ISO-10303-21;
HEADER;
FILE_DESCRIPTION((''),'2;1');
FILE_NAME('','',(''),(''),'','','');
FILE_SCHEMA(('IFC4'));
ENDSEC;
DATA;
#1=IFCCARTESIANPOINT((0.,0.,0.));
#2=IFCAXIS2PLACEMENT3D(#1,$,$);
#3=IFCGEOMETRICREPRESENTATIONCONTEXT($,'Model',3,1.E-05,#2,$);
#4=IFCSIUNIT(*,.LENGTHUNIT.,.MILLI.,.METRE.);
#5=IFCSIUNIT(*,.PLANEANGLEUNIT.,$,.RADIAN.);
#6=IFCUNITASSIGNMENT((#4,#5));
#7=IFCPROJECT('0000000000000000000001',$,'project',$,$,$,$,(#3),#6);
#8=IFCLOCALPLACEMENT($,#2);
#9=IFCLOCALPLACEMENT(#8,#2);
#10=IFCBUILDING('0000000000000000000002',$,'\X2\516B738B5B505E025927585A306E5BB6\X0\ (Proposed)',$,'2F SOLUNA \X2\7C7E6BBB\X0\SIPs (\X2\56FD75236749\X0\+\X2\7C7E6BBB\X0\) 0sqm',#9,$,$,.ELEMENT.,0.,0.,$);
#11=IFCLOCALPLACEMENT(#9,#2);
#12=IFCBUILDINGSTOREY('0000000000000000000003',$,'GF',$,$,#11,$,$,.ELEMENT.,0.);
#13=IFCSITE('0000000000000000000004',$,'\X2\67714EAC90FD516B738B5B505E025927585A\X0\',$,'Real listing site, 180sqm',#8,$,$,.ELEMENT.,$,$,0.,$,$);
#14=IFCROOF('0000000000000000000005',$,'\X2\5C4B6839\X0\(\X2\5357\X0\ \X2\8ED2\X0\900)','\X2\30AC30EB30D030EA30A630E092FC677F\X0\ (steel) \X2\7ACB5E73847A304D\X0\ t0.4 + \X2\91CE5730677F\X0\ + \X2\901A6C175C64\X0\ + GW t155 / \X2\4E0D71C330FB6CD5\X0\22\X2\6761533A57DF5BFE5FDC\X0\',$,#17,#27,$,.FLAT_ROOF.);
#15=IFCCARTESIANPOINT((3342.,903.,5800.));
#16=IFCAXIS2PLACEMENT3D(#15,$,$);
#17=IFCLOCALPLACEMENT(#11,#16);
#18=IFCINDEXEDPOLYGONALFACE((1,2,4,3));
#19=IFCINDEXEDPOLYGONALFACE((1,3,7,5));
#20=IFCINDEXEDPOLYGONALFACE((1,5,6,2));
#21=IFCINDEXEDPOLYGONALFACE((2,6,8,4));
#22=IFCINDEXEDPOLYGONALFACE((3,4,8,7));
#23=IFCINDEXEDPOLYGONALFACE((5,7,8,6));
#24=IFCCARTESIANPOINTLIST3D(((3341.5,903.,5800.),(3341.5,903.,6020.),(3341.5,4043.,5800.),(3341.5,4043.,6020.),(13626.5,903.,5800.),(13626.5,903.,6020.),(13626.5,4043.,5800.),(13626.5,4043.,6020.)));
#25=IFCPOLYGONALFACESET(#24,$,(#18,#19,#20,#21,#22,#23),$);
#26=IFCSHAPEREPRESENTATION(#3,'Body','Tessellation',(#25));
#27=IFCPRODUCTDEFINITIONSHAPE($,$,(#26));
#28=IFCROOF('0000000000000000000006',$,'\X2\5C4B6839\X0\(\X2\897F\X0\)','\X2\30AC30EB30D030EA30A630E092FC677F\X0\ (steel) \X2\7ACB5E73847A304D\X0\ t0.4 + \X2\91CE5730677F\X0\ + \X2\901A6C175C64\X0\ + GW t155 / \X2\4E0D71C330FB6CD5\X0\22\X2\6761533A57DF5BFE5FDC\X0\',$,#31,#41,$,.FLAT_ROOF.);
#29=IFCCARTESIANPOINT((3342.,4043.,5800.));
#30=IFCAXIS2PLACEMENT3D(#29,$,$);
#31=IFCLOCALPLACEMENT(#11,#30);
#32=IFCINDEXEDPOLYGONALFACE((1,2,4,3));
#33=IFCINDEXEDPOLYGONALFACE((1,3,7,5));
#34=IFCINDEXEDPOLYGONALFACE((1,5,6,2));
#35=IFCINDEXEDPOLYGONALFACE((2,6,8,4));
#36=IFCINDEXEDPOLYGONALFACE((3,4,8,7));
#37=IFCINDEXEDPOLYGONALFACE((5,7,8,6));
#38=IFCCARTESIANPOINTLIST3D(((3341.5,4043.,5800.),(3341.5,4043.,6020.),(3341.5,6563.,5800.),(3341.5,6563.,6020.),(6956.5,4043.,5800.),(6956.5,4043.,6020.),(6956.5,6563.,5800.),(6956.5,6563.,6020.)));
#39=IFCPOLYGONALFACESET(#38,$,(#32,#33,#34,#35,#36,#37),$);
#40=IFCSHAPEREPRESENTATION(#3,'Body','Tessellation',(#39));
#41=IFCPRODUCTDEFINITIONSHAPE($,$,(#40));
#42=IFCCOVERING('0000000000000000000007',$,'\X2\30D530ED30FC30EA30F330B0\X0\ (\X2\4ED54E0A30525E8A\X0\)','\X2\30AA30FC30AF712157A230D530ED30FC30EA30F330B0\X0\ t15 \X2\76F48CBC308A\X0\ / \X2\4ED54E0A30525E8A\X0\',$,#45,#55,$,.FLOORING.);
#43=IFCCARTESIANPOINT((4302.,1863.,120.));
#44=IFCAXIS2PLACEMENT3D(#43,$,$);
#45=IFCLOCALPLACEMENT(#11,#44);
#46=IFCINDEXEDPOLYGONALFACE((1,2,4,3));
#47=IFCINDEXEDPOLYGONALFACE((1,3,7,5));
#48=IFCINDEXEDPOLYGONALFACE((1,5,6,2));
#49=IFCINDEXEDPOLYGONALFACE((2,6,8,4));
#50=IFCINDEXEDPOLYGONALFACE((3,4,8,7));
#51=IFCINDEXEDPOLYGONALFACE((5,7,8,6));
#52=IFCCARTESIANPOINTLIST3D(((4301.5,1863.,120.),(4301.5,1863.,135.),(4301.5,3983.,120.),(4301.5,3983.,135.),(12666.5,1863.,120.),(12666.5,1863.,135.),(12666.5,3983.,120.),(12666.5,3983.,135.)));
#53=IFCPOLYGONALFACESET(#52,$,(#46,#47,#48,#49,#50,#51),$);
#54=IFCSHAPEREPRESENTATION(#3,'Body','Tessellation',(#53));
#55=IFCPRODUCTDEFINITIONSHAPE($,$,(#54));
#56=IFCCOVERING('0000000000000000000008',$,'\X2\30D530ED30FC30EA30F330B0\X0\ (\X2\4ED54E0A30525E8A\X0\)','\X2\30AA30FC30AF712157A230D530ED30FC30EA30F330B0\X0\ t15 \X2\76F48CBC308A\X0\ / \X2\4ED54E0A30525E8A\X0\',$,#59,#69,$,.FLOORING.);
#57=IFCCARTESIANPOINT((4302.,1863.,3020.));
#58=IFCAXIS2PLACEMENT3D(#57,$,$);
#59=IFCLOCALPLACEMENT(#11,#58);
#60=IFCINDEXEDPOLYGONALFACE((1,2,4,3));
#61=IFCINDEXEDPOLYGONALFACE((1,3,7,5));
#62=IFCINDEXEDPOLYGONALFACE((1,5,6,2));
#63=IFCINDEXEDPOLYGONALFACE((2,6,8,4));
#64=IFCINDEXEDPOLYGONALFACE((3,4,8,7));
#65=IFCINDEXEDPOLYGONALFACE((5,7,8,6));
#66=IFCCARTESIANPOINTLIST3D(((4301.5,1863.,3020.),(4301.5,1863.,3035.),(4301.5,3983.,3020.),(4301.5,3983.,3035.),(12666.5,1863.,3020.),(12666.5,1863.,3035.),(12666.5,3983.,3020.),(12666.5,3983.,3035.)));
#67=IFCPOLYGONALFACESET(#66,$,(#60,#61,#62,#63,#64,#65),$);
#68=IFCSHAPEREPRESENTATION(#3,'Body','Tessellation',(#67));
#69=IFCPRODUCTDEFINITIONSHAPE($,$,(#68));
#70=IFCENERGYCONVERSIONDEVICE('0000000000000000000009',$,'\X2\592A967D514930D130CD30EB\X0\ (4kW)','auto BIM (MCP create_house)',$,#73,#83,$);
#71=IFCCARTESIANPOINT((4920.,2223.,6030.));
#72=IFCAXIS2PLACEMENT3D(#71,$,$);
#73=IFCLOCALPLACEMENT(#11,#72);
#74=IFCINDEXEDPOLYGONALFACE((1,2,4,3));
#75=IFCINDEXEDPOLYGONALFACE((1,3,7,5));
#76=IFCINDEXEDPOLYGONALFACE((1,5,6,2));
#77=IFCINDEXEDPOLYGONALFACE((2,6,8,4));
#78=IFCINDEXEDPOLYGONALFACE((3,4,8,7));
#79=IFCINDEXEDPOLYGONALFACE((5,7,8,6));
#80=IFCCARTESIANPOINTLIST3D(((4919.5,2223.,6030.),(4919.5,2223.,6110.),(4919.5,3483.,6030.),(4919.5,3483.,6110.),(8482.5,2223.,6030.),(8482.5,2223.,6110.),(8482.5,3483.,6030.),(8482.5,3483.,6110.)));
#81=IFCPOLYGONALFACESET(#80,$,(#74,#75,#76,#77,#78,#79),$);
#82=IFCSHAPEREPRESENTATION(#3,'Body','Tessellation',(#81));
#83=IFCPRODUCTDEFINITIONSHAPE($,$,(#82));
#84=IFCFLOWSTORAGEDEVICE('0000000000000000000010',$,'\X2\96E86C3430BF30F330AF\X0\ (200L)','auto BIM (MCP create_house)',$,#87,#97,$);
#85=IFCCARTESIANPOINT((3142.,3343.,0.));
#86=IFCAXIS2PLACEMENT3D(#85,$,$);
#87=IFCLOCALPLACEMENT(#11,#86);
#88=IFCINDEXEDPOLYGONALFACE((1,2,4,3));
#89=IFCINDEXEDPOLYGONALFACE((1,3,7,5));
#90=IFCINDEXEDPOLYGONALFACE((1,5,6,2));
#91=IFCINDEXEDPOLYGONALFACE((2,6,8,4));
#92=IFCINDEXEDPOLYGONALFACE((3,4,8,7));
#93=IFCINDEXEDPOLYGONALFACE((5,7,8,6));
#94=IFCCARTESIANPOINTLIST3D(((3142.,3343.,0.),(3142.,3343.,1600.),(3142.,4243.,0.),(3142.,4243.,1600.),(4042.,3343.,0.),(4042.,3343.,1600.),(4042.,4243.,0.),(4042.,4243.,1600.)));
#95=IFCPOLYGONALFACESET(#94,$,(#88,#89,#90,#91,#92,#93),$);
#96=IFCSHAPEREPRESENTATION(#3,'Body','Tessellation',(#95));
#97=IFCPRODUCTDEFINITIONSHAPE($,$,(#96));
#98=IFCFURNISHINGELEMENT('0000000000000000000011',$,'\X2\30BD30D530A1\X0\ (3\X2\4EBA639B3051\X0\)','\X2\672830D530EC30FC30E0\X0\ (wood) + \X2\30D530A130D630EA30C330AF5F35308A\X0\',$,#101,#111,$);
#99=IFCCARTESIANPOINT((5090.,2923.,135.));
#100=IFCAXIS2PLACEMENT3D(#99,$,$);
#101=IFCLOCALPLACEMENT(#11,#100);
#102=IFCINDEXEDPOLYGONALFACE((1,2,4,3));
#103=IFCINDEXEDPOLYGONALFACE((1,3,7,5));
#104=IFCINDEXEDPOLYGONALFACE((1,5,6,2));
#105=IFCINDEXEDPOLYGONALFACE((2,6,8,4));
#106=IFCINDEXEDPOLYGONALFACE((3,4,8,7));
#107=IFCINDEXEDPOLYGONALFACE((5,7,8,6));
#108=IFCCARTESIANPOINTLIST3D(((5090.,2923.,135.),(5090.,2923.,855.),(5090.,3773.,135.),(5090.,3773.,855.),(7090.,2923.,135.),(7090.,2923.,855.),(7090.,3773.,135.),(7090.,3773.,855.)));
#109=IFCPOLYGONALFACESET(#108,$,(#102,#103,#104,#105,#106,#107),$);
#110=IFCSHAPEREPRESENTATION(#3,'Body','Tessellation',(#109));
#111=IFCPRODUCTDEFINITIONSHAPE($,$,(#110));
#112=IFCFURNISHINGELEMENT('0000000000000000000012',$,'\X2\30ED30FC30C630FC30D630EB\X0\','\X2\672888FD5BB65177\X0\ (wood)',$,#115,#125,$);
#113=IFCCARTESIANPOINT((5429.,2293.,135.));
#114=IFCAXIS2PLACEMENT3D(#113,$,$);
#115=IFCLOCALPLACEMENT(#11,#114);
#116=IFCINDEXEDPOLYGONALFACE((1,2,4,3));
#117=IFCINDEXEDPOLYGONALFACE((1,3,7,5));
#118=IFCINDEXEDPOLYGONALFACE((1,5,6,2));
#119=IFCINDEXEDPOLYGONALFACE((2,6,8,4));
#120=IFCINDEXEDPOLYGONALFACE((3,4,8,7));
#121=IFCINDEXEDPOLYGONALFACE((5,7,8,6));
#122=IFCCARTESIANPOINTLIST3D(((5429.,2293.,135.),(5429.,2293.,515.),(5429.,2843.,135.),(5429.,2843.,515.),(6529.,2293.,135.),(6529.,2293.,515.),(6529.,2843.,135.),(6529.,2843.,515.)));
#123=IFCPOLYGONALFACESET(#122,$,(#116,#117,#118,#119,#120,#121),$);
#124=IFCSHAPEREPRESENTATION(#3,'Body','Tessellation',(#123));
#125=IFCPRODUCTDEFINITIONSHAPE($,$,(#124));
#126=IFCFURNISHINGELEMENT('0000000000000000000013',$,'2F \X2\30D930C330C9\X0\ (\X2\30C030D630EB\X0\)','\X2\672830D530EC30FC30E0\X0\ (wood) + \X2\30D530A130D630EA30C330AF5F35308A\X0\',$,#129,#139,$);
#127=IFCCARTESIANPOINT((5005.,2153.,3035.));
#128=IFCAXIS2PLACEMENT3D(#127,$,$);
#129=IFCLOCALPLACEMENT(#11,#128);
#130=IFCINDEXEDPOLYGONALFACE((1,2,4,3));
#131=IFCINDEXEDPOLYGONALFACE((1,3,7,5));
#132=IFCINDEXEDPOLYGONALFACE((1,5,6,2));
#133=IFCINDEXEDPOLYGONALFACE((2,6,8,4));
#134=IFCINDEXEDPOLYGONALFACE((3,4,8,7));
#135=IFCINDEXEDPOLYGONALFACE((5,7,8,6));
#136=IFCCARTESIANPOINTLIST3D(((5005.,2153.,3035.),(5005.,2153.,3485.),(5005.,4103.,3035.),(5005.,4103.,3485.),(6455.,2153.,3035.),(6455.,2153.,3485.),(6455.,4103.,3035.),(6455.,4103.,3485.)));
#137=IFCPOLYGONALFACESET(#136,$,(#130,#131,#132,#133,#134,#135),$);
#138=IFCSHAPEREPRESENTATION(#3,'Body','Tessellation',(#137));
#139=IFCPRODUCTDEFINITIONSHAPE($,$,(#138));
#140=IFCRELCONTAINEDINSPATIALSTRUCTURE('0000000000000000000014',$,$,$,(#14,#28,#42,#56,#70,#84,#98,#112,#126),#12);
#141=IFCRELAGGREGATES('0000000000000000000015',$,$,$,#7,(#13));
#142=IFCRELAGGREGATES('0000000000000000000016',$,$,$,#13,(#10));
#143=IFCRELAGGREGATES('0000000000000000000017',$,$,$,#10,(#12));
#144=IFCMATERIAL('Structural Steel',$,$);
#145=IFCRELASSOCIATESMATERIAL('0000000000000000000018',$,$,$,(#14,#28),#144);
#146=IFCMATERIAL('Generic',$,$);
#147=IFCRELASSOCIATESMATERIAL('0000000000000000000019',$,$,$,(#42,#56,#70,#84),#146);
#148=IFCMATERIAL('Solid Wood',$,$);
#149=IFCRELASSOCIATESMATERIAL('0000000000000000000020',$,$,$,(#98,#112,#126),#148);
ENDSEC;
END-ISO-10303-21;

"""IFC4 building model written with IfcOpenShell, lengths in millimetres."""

from ifc_helpers import new_model, si_unit, frame, frame_2d, origin, place, context, project, spatial, rectangle, extrude, material, element, save


model = new_model("IFC4")

# Units and contexts
model_context = context("Model", 3, precision=1e-05, world=origin())
ifc_project = project(units=[si_unit("LENGTHUNIT", "METRE", prefix="MILLI"), si_unit("PLANEANGLEUNIT", "RADIAN")], contexts=[model_context])

# Site, building, storey
site_placement = place(None, origin())
site = spatial("IfcSite", under=ifc_project, at=site_placement, Name="東京都八王子市大塚", ObjectType="Real listing site, 180sqm", CompositionType="ELEMENT", RefElevation=0.0)
building_placement = place(site_placement, origin())
building = spatial("IfcBuilding", under=site, at=building_placement, Name="八王子市大塚の家 (Proposed)", ObjectType="2F SOLUNA 籾殻SIPs (国産杉+籾殻) 0sqm", CompositionType="ELEMENT", ElevationOfRefHeight=0.0, ElevationOfTerrain=0.0)
storey_placement = place(building_placement, origin())
storey = spatial("IfcBuildingStorey", under=building, at=storey_placement, Name="GF", CompositionType="ELEMENT", Elevation=0.0)

# Shared definitions
ifc_material_1 = material(Name="Solid Wood")

# Roofs
ifc_material_2 = material(Name="Structural Steel")
roof_1_placement = place(storey_placement, frame((3342.0, 903.0, 5800.0)))
element("IfcRoof", 1, at=roof_1_placement, inside=storey, material=ifc_material_2, Name="屋根(南 軒900)", Description="ガルバリウム鋼板 (steel) 立平葺き t0.4 + 野地板 + 通気層 + GW t155 / 不燃・法22条区域対応", PredefinedType="FLAT_ROOF", context=model_context, shape_type="SweptSolid", body=[
    extrude(rectangle(XDim=10285.0, YDim=3140.0, at=frame_2d((5142.0, 1570.0))), frame((3342.0, 903.0, 5800.0)), (0.0, 0.0, 1.0), 220.0),
])
roof_2_placement = place(storey_placement, frame((3342.0, 4043.0, 5800.0)))
element("IfcRoof", 2, at=roof_2_placement, inside=storey, material=ifc_material_2, Name="屋根(西)", Description="ガルバリウム鋼板 (steel) 立平葺き t0.4 + 野地板 + 通気層 + GW t155 / 不燃・法22条区域対応", PredefinedType="FLAT_ROOF", context=model_context, shape_type="SweptSolid", body=[
    extrude(rectangle(XDim=3615.0, YDim=2520.0, at=frame_2d((1807.0, 1260.0))), frame((3342.0, 4043.0, 5800.0)), (0.0, 0.0, 1.0), 220.0),
])

# Coverings
ifc_material_3 = material(Name="Generic")
covering_1_placement = place(storey_placement, frame((4302.0, 1863.0, 120.0)))
element("IfcCovering", 3, at=covering_1_placement, inside=storey, material=ifc_material_3, Name="フローリング (仕上げ床)", Description="オーク無垢フローリング t15 直貼り / 仕上げ床", PredefinedType="FLOORING", context=model_context, shape_type="SweptSolid", body=[
    extrude(rectangle(XDim=8365.0, YDim=2120.0, at=frame_2d((4182.0, 1060.0))), frame((4302.0, 1863.0, 120.0)), (0.0, 0.0, 1.0), 15.0),
])
covering_2_placement = place(storey_placement, frame((4302.0, 1863.0, 3020.0)))
element("IfcCovering", 4, at=covering_2_placement, inside=storey, material=ifc_material_3, Name="フローリング (仕上げ床)", Description="オーク無垢フローリング t15 直貼り / 仕上げ床", PredefinedType="FLOORING", context=model_context, shape_type="SweptSolid", body=[
    extrude(rectangle(XDim=8365.0, YDim=2120.0, at=frame_2d((4182.0, 1060.0))), frame((4302.0, 1863.0, 3020.0)), (0.0, 0.0, 1.0), 15.0),
])

# Energy conversion device
energy_conversion_device_placement = place(storey_placement, frame((4920.0, 2223.0, 6030.0)))
element("IfcEnergyConversionDevice", 5, at=energy_conversion_device_placement, inside=storey, material=ifc_material_3, Name="太陽光パネル (4kW)", Description="auto BIM (MCP create_house)", context=model_context, shape_type="SweptSolid", body=[
    extrude(rectangle(XDim=3563.0, YDim=1260.0, at=frame_2d((1781.0, 630.0))), frame((4920.0, 2223.0, 6030.0)), (0.0, 0.0, 1.0), 80.0),
])

# Flow storage device
flow_storage_device_placement = place(storey_placement, frame((3142.0, 3343.0, 0.0)))
element("IfcFlowStorageDevice", 6, at=flow_storage_device_placement, inside=storey, material=ifc_material_3, Name="雨水タンク (200L)", Description="auto BIM (MCP create_house)", context=model_context, shape_type="SweptSolid", body=[
    extrude(rectangle(XDim=900.0, YDim=900.0, at=frame_2d((450.0, 450.0))), frame((3142.0, 3343.0, 0.0)), (0.0, 0.0, 1.0), 1600.0),
])

# Furnishing elements
furnishing_1_placement = place(storey_placement, frame((5090.0, 2923.0, 135.0)))
element("IfcFurnishingElement", 7, at=furnishing_1_placement, inside=storey, material=ifc_material_1, Name="ソファ (3人掛け)", Description="木フレーム (wood) + ファブリック張り", context=model_context, shape_type="SweptSolid", body=[
    extrude(rectangle(XDim=2000.0, YDim=850.0, at=frame_2d((1000.0, 425.0))), frame((5090.0, 2923.0, 135.0)), (0.0, 0.0, 1.0), 720.0),
])
furnishing_2_placement = place(storey_placement, frame((5429.0, 2293.0, 135.0)))
element("IfcFurnishingElement", 8, at=furnishing_2_placement, inside=storey, material=ifc_material_1, Name="ローテーブル", Description="木製家具 (wood)", context=model_context, shape_type="SweptSolid", body=[
    extrude(rectangle(XDim=1100.0, YDim=550.0, at=frame_2d((550.0, 275.0))), frame((5429.0, 2293.0, 135.0)), (0.0, 0.0, 1.0), 380.0),
])
furnishing_3_placement = place(storey_placement, frame((5005.0, 2153.0, 3035.0)))
element("IfcFurnishingElement", 9, at=furnishing_3_placement, inside=storey, material=ifc_material_1, Name="2F ベッド (ダブル)", Description="木フレーム (wood) + ファブリック張り", context=model_context, shape_type="SweptSolid", body=[
    extrude(rectangle(XDim=1450.0, YDim=1950.0, at=frame_2d((725.0, 975.0))), frame((5005.0, 2153.0, 3035.0)), (0.0, 0.0, 1.0), 450.0),
])

save(model, "model.ifc")
